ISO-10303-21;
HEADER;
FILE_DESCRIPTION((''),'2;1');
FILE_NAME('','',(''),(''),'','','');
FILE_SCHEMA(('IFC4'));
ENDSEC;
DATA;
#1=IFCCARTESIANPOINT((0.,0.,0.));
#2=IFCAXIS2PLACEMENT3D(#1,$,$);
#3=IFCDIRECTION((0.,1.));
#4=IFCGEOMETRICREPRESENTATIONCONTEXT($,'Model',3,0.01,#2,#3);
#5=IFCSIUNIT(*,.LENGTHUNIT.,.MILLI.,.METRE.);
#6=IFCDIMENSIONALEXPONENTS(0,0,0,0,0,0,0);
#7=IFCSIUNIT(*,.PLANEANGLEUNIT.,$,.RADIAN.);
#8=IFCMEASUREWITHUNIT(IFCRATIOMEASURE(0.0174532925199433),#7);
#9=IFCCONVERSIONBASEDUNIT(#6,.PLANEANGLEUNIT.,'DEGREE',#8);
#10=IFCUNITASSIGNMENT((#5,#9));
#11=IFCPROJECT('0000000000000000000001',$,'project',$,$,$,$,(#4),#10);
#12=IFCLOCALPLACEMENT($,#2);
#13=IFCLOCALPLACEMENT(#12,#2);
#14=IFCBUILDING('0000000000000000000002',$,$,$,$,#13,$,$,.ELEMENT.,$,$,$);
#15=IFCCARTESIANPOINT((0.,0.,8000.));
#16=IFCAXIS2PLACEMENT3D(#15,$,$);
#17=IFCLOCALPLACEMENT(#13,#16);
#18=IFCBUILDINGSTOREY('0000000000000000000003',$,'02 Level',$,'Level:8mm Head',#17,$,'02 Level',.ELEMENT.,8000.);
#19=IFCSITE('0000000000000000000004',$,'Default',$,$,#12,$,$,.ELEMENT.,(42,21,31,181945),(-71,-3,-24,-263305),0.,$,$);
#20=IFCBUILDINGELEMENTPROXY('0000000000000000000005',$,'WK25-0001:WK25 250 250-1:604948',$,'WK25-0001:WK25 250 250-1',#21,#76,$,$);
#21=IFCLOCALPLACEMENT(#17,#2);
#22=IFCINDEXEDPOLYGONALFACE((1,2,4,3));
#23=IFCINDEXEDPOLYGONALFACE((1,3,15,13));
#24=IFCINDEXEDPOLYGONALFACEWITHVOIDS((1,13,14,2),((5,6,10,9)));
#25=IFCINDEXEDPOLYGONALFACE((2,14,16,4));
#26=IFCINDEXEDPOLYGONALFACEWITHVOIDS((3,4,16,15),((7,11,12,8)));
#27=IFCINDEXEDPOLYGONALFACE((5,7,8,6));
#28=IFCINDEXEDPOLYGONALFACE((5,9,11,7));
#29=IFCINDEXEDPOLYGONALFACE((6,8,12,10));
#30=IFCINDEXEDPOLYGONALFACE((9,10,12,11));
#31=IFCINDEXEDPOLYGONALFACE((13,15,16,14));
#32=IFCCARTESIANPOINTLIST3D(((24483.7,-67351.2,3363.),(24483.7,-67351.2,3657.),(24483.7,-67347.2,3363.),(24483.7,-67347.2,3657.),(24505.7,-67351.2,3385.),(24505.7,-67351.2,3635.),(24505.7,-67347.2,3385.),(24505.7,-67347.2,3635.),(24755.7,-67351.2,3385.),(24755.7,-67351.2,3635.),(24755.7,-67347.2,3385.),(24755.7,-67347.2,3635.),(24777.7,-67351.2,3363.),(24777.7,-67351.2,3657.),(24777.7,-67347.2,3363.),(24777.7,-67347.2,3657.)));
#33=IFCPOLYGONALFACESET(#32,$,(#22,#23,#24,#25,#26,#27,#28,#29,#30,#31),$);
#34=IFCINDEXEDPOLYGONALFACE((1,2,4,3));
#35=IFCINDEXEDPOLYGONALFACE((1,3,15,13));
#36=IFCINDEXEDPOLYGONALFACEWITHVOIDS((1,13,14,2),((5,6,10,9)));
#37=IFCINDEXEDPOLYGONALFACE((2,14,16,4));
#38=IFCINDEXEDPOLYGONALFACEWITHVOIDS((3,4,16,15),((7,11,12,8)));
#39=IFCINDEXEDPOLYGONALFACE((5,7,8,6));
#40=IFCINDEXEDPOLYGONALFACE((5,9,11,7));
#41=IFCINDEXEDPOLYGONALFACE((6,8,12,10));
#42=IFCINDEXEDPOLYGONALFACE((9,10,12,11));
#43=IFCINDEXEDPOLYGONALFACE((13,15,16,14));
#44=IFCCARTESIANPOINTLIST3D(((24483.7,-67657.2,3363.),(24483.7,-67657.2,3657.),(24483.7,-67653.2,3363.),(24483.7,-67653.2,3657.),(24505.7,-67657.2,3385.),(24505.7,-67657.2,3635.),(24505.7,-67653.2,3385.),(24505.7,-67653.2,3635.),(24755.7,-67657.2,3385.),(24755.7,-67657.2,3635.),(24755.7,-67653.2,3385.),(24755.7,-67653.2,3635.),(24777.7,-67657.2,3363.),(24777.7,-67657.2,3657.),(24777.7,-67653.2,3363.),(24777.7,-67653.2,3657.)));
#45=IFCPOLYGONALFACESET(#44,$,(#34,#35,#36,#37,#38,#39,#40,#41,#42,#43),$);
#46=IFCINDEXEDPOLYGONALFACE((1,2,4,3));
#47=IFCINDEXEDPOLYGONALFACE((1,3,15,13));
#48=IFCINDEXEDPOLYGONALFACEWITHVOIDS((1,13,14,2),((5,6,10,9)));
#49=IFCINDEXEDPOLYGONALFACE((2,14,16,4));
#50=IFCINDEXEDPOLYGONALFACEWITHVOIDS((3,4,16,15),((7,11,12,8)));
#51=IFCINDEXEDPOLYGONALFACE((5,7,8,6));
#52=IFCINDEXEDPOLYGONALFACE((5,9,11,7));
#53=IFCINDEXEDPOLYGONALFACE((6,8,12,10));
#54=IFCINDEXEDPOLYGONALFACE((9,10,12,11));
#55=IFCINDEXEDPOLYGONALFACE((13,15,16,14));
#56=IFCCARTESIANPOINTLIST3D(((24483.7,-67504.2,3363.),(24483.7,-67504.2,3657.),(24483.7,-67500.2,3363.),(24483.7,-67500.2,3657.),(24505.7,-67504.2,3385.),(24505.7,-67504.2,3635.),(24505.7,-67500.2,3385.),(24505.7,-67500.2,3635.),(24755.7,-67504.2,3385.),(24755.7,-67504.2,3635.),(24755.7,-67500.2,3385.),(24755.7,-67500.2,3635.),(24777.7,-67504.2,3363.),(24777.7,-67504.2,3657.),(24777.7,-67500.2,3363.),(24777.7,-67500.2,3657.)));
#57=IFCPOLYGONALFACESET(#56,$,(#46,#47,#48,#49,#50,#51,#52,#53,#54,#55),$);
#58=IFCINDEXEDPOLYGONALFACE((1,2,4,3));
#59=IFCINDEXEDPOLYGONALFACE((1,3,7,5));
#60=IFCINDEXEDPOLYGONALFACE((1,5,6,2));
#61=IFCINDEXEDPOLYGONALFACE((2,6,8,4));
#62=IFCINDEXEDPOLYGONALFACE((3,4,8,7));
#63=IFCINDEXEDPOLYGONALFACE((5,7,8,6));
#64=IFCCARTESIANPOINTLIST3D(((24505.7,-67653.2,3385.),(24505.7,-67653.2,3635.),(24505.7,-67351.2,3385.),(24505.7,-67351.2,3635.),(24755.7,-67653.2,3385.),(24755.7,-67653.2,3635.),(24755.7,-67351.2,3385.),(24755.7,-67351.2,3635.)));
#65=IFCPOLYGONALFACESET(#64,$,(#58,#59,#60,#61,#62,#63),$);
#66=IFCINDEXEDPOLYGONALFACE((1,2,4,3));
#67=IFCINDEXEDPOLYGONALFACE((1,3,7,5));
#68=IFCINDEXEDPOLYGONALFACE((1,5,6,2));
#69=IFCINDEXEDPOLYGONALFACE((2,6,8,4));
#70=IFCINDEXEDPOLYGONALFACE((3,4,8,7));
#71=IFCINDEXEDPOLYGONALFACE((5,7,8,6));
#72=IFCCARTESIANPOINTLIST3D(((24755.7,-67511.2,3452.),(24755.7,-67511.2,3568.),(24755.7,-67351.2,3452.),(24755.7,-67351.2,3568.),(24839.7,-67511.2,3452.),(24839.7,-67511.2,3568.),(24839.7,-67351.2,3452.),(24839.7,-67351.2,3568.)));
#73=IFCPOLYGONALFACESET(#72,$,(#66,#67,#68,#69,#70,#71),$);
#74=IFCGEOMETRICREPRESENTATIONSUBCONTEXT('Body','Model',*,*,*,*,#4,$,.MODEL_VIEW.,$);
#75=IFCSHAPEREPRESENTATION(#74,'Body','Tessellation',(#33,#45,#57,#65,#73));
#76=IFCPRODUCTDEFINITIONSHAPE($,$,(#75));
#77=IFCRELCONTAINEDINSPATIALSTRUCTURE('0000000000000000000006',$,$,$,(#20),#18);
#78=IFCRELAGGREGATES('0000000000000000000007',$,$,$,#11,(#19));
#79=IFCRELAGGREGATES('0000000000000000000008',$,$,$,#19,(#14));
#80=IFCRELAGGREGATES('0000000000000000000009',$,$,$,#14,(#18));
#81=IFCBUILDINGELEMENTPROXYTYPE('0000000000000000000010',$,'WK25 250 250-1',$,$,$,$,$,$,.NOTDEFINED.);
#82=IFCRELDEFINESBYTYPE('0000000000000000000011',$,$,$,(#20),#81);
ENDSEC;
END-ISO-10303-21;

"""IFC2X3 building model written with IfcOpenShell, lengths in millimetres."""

from ifc_helpers import new_model, entity, si_unit, converted_unit, direction, frame, frame_2d, origin, origin_2d_with_axis, place, context, subcontext, project, spatial, polyline, rectangle, outline, extrude, source, transform, mapped, type_object, type_shapes, element, save


model = new_model("IFC2X3")

# Units and contexts
model_context = context("Model", 3, precision=0.01, world=origin(), true_north=direction((0.0, 1.0)))
body_context = subcontext(model_context, "Body", "Model", "MODEL_VIEW")
ifc_project = project(units=[si_unit("LENGTHUNIT", "METRE", prefix="MILLI"), converted_unit("PLANEANGLEUNIT", "DEGREE", entity("IfcRatioMeasure", 0.0174532925199433), si_unit("PLANEANGLEUNIT", "RADIAN"), dimensions=[0, 0, 0, 0, 0, 0, 0])], contexts=[model_context])

# Site, building, storey
site_placement = place(None, origin())
site = spatial("IfcSite", under=ifc_project, at=site_placement, Name="Default", CompositionType="ELEMENT", RefLatitude=(42, 21, 31, 181945), RefLongitude=(-71, -3, -24, -263305), RefElevation=0.0)
building_placement = place(site_placement, origin())
building = spatial("IfcBuilding", under=site, at=building_placement, CompositionType="ELEMENT")
storey_placement = place(building_placement, frame((0.0, 0.0, 8000.0)))
storey = spatial("IfcBuildingStorey", under=building, at=storey_placement, Name="02 Level", ObjectType="Level:8mm Head", LongName="02 Level", CompositionType="ELEMENT", Elevation=8000.0)

# Building element proxy
building_element_proxy_type_1 = type_object("IfcBuildingElementProxyType", Name="WK25 250 250-1", PredefinedType="NOTDEFINED")
shared_shape_1 = source(origin(), body_context, "Body", "SweptSolid", [
    extrude(outline(polyline([(-147.0, -147.0), (147.0, -147.0), (147.0, 147.0), (-147.0, 147.0), (-147.0, -147.0)]), holes=[polyline([(-125.0, -125.0), (-125.0, 125.0), (125.0, 125.0), (125.0, -125.0), (-125.0, -125.0)])]), frame((151.0, 0.0, 0.0), z_axis=(1.0, 0.0, 0.0), x_axis=(0.0, -1.0, 0.0)), (0.0, 0.0, 1.0), 4.0),
    extrude(outline(polyline([(-147.0, -147.0), (147.0, -147.0), (147.0, 147.0), (-147.0, 147.0), (-147.0, -147.0)]), holes=[polyline([(-125.0, -125.0), (-125.0, 125.0), (125.0, 125.0), (125.0, -125.0), (-125.0, -125.0)])]), frame((-155.0, 0.0, 0.0), z_axis=(1.0, 0.0, 0.0), x_axis=(0.0, 0.0, -1.0)), (0.0, 0.0, 1.0), 4.0),
    extrude(outline(polyline([(-147.0, -147.0), (147.0, -147.0), (147.0, 147.0), (-147.0, 147.0), (-147.0, -147.0)]), holes=[polyline([(-125.0, -125.0), (-125.0, 125.0), (125.0, 125.0), (125.0, -125.0), (-125.0, -125.0)])]), frame((-2.0, 0.0, 0.0), z_axis=(1.0, 0.0, 0.0), x_axis=(0.0, 0.0, -1.0)), (0.0, 0.0, 1.0), 4.0),
    extrude(rectangle(XDim=250.0, YDim=302.0, at=origin_2d_with_axis()), frame((0.0, 0.0, -125.0), z_axis=(0.0, 0.0, 1.0), x_axis=(0.0, 1.0, 0.0)), (0.0, 0.0, 1.0), 250.0),
    extrude(rectangle(XDim=160.0, YDim=84.0, at=frame_2d((0.0, 0.0), x_axis=(1.0, 0.0))), frame((71.0, 167.0, -58.0)), (0.0, 0.0, 1.0), 116.0),
])
type_shapes(building_element_proxy_type_1, [shared_shape_1])
proxy_1_placement = place(storey_placement, frame((24630.7, -67502.2, 3510.0), z_axis=(0.0, 0.0, -1.0), x_axis=(0.0, 1.0, 0.0)))
element("IfcBuildingElementProxy", 1, at=proxy_1_placement, inside=storey, type_object=building_element_proxy_type_1, Name="WK25-0001:WK25 250 250-1:604948", ObjectType="WK25-0001:WK25 250 250-1", context=body_context, shape_type="MappedRepresentation", body=[
    mapped(shared_shape_1, transform((0.0, 0.0, 0.0), scale=1.0)),
])

save(model, "model.ifc")
